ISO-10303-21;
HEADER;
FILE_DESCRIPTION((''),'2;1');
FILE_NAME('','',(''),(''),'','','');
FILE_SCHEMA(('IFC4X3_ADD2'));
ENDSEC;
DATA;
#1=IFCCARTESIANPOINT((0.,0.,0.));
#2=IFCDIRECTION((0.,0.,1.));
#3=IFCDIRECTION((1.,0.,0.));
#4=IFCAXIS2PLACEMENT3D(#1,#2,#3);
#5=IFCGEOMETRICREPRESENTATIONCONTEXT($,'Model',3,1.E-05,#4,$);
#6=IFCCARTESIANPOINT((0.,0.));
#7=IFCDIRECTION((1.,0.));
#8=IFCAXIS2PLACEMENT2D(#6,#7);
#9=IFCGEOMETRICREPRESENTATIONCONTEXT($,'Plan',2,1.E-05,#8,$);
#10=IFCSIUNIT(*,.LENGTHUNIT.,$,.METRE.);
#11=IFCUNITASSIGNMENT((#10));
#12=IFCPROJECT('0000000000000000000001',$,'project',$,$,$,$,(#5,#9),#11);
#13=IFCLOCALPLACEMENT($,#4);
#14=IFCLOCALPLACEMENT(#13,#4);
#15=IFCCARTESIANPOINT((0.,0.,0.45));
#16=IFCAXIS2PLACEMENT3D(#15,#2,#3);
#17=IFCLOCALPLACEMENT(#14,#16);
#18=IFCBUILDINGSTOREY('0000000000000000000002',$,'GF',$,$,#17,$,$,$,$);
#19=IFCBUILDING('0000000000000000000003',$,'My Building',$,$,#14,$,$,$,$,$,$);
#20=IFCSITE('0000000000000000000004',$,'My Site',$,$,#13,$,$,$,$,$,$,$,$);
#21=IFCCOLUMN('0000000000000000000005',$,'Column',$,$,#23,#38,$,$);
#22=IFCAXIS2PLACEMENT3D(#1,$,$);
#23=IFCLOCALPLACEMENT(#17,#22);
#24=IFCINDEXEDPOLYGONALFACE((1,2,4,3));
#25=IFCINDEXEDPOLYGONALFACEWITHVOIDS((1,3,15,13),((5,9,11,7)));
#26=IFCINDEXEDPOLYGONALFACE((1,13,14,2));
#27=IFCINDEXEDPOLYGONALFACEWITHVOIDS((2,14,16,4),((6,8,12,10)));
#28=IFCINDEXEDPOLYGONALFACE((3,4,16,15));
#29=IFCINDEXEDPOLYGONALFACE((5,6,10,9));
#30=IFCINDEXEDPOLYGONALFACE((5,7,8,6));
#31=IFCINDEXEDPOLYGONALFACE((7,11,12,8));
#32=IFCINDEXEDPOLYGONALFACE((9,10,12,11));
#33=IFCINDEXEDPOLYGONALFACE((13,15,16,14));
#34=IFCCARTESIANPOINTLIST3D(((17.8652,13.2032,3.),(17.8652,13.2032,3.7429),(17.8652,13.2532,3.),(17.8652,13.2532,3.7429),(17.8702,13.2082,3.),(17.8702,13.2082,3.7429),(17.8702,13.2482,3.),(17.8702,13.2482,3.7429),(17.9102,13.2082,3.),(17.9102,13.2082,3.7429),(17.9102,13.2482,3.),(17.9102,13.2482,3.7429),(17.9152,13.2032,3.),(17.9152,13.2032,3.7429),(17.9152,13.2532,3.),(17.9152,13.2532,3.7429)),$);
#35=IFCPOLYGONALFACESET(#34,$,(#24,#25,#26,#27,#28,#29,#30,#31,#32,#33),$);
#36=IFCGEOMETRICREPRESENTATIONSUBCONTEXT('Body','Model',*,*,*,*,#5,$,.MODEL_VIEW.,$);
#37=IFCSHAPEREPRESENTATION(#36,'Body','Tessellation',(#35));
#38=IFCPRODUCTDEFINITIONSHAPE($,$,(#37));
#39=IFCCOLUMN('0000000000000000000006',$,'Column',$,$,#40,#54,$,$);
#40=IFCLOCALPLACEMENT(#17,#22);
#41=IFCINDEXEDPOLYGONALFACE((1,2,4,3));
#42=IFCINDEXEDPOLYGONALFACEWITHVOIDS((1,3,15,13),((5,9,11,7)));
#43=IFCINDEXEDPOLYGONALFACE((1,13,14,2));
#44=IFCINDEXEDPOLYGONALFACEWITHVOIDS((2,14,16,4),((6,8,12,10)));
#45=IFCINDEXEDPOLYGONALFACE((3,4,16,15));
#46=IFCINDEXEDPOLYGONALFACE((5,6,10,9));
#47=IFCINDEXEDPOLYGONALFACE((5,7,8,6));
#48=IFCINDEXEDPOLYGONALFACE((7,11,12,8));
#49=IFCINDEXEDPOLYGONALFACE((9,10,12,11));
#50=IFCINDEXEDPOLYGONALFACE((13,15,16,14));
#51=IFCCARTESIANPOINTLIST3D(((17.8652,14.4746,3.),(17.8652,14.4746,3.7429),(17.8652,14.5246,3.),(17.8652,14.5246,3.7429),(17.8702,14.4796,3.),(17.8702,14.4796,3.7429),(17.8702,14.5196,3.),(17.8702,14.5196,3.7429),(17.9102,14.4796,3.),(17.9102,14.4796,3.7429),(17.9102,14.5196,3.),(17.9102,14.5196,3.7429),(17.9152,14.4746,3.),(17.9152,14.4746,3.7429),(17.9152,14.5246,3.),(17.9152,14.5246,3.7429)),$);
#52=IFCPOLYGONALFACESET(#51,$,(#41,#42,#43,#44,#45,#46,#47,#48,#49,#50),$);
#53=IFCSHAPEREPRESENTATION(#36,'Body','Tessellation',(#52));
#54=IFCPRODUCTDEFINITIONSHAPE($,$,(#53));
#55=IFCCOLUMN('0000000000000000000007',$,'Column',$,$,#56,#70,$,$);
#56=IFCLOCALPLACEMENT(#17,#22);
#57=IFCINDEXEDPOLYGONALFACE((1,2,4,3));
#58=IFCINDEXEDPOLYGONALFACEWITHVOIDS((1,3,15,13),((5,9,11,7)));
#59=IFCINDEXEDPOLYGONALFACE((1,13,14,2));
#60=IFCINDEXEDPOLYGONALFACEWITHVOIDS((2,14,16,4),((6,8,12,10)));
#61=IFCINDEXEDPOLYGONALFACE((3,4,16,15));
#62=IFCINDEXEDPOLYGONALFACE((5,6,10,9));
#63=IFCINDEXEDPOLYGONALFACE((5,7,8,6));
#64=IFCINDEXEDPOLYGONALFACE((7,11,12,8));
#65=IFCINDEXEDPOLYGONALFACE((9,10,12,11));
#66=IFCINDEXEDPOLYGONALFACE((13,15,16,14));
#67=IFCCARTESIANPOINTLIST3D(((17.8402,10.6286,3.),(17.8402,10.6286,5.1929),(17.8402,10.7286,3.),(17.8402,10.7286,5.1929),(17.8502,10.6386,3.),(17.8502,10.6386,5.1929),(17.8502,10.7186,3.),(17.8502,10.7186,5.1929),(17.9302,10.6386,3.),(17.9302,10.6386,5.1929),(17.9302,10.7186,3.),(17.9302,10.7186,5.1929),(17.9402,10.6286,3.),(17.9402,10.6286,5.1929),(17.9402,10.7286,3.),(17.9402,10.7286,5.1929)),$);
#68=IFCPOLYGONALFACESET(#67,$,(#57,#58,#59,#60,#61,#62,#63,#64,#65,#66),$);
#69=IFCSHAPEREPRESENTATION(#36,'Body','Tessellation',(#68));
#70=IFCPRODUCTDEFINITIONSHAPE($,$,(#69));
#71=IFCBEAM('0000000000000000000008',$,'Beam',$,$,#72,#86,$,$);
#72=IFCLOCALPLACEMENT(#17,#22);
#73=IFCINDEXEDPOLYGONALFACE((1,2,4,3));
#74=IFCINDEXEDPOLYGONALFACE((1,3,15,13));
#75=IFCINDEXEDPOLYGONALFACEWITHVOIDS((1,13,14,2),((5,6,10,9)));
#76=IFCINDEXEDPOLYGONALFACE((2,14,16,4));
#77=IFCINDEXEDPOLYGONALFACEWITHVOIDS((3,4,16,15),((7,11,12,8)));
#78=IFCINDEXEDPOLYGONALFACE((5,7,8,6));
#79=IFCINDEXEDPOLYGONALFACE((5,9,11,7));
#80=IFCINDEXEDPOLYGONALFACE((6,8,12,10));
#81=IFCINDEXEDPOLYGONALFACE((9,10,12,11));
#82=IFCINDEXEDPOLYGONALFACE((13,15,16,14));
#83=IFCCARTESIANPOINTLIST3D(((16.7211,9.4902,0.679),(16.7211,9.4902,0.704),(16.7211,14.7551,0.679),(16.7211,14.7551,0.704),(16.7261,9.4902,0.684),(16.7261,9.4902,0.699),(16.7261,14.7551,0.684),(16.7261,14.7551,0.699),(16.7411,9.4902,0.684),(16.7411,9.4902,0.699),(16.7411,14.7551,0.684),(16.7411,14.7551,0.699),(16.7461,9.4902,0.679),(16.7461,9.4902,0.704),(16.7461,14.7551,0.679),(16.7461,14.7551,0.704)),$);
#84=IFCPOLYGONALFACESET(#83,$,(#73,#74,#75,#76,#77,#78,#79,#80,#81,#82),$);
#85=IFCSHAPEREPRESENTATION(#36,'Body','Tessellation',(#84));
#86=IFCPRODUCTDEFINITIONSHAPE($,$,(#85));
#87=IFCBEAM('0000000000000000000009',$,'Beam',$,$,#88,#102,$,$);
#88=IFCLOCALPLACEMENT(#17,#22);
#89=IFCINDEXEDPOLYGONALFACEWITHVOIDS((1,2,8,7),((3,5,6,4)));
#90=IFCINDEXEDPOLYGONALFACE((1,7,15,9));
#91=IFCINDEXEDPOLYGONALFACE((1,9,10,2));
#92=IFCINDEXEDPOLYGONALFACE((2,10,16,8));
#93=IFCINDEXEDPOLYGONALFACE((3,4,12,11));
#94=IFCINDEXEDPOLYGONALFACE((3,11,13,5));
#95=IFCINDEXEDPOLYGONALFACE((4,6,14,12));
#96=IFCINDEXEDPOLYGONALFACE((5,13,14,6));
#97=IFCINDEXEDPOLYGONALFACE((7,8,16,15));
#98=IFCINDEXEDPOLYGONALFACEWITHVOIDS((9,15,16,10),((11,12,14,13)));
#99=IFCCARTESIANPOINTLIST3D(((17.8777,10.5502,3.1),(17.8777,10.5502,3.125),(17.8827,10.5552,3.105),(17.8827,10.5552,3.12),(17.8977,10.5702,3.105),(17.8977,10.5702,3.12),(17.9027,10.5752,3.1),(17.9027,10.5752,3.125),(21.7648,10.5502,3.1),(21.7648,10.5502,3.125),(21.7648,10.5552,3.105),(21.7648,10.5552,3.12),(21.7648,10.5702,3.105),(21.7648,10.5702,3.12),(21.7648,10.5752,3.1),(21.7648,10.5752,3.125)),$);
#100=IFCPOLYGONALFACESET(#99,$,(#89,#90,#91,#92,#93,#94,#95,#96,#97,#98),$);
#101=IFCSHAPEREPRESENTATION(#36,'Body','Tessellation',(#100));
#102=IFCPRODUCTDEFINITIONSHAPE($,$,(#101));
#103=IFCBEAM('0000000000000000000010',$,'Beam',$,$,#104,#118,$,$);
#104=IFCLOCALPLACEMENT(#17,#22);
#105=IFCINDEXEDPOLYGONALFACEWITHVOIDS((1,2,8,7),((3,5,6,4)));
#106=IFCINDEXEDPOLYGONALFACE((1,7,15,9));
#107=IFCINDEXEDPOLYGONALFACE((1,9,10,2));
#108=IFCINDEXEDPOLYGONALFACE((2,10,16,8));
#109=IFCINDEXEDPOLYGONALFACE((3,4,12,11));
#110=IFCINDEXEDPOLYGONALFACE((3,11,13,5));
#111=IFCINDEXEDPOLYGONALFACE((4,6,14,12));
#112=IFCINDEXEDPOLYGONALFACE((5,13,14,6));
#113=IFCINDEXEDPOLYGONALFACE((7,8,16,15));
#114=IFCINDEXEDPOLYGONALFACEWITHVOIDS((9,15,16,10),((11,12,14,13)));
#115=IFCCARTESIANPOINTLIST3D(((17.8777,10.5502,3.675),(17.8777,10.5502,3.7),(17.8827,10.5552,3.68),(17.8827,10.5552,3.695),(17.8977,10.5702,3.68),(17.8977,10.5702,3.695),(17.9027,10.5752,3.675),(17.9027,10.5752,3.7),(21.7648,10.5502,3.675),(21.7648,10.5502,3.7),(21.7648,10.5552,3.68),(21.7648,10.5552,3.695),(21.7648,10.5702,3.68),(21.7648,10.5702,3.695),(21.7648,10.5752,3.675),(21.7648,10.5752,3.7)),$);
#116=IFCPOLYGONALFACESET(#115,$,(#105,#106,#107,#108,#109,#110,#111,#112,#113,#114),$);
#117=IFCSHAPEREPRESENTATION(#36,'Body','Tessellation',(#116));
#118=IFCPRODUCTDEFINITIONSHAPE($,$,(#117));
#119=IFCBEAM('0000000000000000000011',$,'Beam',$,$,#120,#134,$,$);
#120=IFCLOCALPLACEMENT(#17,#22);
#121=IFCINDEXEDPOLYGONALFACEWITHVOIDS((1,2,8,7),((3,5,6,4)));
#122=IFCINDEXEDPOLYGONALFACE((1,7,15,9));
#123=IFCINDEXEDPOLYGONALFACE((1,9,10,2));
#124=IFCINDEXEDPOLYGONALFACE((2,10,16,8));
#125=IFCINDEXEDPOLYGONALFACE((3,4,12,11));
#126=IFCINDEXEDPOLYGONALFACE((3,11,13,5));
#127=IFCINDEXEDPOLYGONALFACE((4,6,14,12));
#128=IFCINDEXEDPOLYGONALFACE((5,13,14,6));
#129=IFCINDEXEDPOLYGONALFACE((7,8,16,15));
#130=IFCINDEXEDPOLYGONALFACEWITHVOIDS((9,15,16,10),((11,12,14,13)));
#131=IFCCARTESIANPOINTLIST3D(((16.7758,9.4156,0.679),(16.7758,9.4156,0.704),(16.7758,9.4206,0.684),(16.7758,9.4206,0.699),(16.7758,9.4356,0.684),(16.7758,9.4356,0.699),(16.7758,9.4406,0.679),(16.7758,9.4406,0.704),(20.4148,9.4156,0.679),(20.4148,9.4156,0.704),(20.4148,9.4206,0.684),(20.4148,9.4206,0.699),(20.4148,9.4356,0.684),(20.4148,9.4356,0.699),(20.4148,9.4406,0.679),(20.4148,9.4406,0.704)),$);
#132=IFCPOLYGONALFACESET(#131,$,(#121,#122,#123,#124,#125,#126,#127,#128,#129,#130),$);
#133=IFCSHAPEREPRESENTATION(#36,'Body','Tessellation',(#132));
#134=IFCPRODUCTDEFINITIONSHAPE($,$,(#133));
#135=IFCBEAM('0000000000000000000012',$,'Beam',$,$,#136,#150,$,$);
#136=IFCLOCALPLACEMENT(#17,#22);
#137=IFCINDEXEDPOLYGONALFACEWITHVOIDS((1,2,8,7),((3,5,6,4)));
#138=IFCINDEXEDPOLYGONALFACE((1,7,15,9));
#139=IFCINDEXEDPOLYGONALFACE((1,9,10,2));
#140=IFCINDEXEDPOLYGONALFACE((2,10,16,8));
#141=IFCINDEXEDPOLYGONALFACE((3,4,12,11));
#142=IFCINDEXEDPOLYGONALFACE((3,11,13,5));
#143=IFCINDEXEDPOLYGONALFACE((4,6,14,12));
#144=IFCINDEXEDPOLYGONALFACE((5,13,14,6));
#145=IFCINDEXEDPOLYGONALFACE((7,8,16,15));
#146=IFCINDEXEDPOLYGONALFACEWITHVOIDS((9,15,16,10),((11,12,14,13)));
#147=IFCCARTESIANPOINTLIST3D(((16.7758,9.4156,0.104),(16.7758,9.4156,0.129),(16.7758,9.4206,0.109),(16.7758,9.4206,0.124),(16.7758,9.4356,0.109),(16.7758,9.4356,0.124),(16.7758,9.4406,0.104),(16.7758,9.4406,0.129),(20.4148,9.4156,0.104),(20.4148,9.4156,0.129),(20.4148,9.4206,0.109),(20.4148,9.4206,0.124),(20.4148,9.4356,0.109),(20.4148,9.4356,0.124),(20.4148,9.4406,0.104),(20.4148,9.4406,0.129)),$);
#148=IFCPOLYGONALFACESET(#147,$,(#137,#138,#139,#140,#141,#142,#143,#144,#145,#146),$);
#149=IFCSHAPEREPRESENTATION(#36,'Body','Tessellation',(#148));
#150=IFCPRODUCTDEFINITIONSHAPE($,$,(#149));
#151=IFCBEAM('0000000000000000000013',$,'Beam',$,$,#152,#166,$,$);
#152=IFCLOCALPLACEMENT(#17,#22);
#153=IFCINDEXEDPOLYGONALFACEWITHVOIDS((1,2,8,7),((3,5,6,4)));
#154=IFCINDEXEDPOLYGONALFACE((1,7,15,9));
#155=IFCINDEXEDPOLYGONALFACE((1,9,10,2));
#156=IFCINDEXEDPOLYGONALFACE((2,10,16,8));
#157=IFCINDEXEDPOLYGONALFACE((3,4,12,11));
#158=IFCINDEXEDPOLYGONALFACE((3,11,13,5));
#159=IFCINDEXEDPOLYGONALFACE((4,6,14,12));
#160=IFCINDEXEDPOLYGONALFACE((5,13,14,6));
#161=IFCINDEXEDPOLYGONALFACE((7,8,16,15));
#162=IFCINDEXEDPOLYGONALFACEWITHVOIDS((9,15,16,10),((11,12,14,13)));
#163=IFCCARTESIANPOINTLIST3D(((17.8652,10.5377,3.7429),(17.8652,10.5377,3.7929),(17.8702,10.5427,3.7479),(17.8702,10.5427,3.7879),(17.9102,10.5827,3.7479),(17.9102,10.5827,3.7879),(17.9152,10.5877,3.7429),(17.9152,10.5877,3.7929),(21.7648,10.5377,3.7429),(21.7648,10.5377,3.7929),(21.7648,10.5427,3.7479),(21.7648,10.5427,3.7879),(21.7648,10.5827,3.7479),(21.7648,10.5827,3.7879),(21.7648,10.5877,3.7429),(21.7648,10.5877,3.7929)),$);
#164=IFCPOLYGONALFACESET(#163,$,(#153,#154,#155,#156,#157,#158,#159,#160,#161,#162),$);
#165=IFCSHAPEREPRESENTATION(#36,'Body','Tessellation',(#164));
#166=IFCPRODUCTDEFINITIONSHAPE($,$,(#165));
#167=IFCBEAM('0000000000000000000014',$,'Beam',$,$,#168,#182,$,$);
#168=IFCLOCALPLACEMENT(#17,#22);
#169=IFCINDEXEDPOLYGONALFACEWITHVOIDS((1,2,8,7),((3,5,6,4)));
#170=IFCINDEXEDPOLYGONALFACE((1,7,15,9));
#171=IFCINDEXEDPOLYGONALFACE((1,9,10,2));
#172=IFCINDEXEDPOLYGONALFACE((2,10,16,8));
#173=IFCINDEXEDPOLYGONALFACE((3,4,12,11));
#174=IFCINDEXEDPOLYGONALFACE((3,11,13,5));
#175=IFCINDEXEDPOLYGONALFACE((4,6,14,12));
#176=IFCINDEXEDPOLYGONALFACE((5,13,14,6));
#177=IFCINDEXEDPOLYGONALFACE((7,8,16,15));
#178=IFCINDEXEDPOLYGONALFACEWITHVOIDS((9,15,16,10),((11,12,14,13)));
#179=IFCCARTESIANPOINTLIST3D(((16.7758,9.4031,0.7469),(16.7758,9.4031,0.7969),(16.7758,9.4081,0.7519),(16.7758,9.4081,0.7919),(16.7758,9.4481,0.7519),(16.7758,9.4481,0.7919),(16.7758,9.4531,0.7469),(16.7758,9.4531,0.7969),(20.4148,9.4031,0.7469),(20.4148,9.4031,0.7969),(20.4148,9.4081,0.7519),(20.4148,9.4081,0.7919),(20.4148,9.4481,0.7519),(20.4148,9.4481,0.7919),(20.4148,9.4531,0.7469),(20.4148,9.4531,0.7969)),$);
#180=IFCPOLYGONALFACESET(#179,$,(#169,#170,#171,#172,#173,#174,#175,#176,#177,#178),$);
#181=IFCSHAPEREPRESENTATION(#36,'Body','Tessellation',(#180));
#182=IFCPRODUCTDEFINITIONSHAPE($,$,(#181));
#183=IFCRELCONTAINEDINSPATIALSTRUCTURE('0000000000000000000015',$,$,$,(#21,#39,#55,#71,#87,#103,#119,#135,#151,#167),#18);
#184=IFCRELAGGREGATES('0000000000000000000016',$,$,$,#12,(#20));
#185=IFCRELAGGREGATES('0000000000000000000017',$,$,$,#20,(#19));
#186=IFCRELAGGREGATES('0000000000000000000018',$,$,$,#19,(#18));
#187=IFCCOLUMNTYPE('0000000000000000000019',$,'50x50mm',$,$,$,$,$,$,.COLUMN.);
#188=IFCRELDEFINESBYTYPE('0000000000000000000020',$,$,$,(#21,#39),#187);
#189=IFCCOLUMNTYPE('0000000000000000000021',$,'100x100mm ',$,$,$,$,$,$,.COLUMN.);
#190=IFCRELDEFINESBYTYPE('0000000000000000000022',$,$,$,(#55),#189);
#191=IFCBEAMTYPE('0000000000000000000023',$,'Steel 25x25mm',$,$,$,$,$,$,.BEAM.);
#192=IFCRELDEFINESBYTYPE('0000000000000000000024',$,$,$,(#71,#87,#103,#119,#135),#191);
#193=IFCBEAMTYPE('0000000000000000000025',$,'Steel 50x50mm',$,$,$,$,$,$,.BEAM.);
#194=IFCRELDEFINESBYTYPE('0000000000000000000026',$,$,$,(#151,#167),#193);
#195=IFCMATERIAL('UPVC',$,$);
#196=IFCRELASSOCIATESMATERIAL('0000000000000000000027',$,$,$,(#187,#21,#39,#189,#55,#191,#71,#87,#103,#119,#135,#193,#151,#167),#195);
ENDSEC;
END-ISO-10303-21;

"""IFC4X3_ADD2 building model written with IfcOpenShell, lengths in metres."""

from ifc_helpers import new_model, entity, si_unit, frame, origin_with_axes, origin_2d_with_axis, place, context, subcontext, project, spatial, hollow_rectangle, extrude, clip, halfspace, shape, material, material_profile, profile_set, profile_usage, type_object, element, save


model = new_model("IFC4X3_ADD2")

# Units and contexts
model_context = context("Model", 3, precision=1e-05, world=origin_with_axes())
plan_context = context("Plan", 2, precision=1e-05, world=origin_2d_with_axis())
body_context_1 = subcontext(model_context, "Body", "Model", "MODEL_VIEW")
body_context_2 = subcontext(plan_context, "Body", "Plan", "PLAN_VIEW")
ifc_project = project(units=[si_unit("LENGTHUNIT", "METRE")], contexts=[model_context, plan_context])

# Site, building, storey
site_placement = place(None, origin_with_axes())
site = spatial("IfcSite", under=ifc_project, at=site_placement, Name="My Site")
building_placement = place(site_placement, origin_with_axes())
building = spatial("IfcBuilding", under=site, at=building_placement, Name="My Building")
storey_placement = place(building_placement, frame((0.0, 0.0, 0.45), z_axis=(0.0, 0.0, 1.0), x_axis=(1.0, 0.0, 0.0)))
storey = spatial("IfcBuildingStorey", under=building, at=storey_placement, Name="GF")

# Columns
ifc_material_1 = material(Name="UPVC")
ifc_material_profile_1 = material_profile(ifc_material_1, hollow_rectangle(XDim=0.05, YDim=0.05, WallThickness=0.005))
ifc_profile_set_1 = profile_set([ifc_material_profile_1])
column_type_1 = type_object("IfcColumnType", Name="50x50mm", PredefinedType="COLUMN", material=ifc_profile_set_1)
ifc_profile_usage_1 = profile_usage(ifc_profile_set_1)
column_1_placement = place(storey_placement, frame((17.8902, 13.2282, 3.0), z_axis=(0.0, 0.0, 1.0), x_axis=(0.0, -1.0, 0.0)))
element("IfcColumn", 1, at=column_1_placement, inside=storey, type_object=column_type_1, material=ifc_profile_usage_1, Name="Column", context=body_context_1, shape_type="SweptSolid", body=[
    extrude(hollow_rectangle(XDim=0.05, YDim=0.05, WallThickness=0.005), origin_with_axes(), (0.0, 0.0, 1.0), 0.7429),
])
ifc_profile_usage_2 = profile_usage(ifc_profile_set_1)
column_2_placement = place(storey_placement, frame((17.8902, 14.4996, 3.0), z_axis=(0.0, 0.0, 1.0), x_axis=(0.0, -1.0, 0.0)))
element("IfcColumn", 2, at=column_2_placement, inside=storey, type_object=column_type_1, material=ifc_profile_usage_2, Name="Column", context=body_context_1, shape_type="SweptSolid", body=[
    extrude(hollow_rectangle(XDim=0.05, YDim=0.05, WallThickness=0.005), origin_with_axes(), (0.0, 0.0, 1.0), 0.7429),
])
ifc_material_profile_2 = material_profile(ifc_material_1, hollow_rectangle(XDim=0.1, YDim=0.1, WallThickness=0.01))
ifc_profile_set_2 = profile_set([ifc_material_profile_2])
ifc_profile_usage_3 = profile_usage(ifc_profile_set_2)
column_type_2 = type_object("IfcColumnType", Name="100x100mm ", PredefinedType="COLUMN", material=ifc_profile_set_2)
column_3_placement = place(storey_placement, frame((17.8902, 10.6786, 3.0), z_axis=(0.0, 0.0, 1.0), x_axis=(0.0, -1.0, 0.0)))
element("IfcColumn", 3, at=column_3_placement, inside=storey, type_object=column_type_2, material=ifc_profile_usage_3, Name="Column", shapes=[
    shape(body_context_1, "Body", "SweptSolid", [extrude(hollow_rectangle(XDim=0.1, YDim=0.1, WallThickness=0.01), origin_with_axes(), (0.0, 0.0, 1.0), 2.1929)]),
    shape(body_context_2, "Body", "Annotation2D", [entity("IfcGeometricCurveSet", [entity("IfcIndexedPolyCurve", entity("IfcCartesianPointList2D", [[0.04, -0.04], [0.04, 0.04], [-0.04, 0.04], [-0.04, -0.04]]), [entity("IfcLineIndex", [1, 2, 3, 4, 1])]), entity("IfcIndexedPolyCurve", entity("IfcCartesianPointList2D", [[-0.05, -0.05], [0.05, -0.05], [0.05, 0.05], [-0.05, 0.05]]), [entity("IfcLineIndex", [1, 2, 3, 4, 1])])])]),
])

# Beams
ifc_material_profile_3 = material_profile(ifc_material_1, hollow_rectangle(XDim=0.025, YDim=0.025, WallThickness=0.005))
ifc_profile_set_3 = profile_set([ifc_material_profile_3])
ifc_profile_usage_4 = profile_usage(ifc_profile_set_3)
beam_type_1 = type_object("IfcBeamType", Name="Steel 25x25mm", PredefinedType="BEAM", material=ifc_profile_set_3)
beam_1_placement = place(storey_placement, frame((16.7336, 14.7551, 0.6915), z_axis=(0.0, -1.0, 0.0), x_axis=(1.0, 0.0, 0.0)))
element("IfcBeam", 4, at=beam_1_placement, inside=storey, type_object=beam_type_1, material=ifc_profile_usage_4, Name="Beam", context=body_context_1, shape_type="SweptSolid", body=[
    extrude(hollow_rectangle(XDim=0.025, YDim=0.025, WallThickness=0.005), origin_with_axes(), (0.0, 0.0, 1.0), 5.2649),
])
ifc_profile_usage_5 = profile_usage(ifc_profile_set_3)
beam_2_placement = place(storey_placement, frame((17.8777, 10.5627, 3.1125), z_axis=(1.0, 0.0, 0.0), x_axis=(0.0, 1.0, 0.0)))
element("IfcBeam", 5, at=beam_2_placement, inside=storey, type_object=beam_type_1, material=ifc_profile_usage_5, Name="Beam", context=body_context_1, shape_type="Clipping", body=[
    clip(extrude(hollow_rectangle(XDim=0.025, YDim=0.025, WallThickness=0.005), origin_with_axes(), (0.0, 0.0, 1.0), 3.8871), halfspace(frame((-0.0125, -3.5625, 0.0), z_axis=(0.707134, 0.0, -0.70708), x_axis=(0.0, -1.0, 0.0)), False)),
])
ifc_profile_usage_6 = profile_usage(ifc_profile_set_3)
beam_3_placement = place(storey_placement, frame((17.8777, 10.5627, 3.6875), z_axis=(1.0, 0.0, 0.0), x_axis=(0.0, 1.0, 0.0)))
element("IfcBeam", 6, at=beam_3_placement, inside=storey, type_object=beam_type_1, material=ifc_profile_usage_6, Name="Beam", context=body_context_1, shape_type="Clipping", body=[
    clip(extrude(hollow_rectangle(XDim=0.025, YDim=0.025, WallThickness=0.005), origin_with_axes(), (0.0, 0.0, 1.0), 3.8871), halfspace(frame((-0.0125, -4.1375, 0.0), z_axis=(0.707134, 0.0, -0.70708), x_axis=(0.0, -1.0, 0.0)), False)),
])
ifc_profile_usage_7 = profile_usage(ifc_profile_set_3)
beam_4_placement = place(storey_placement, frame((16.7758, 9.4281, 0.6915), z_axis=(1.0, 0.0, 0.0), x_axis=(0.0, 1.0, 0.0)))
element("IfcBeam", 7, at=beam_4_placement, inside=storey, type_object=beam_type_1, material=ifc_profile_usage_7, Name="Beam", context=body_context_1, shape_type="SweptSolid", body=[
    extrude(hollow_rectangle(XDim=0.025, YDim=0.025, WallThickness=0.005), origin_with_axes(), (0.0, 0.0, 1.0), 3.6389),
])
ifc_profile_usage_8 = profile_usage(ifc_profile_set_3)
beam_5_placement = place(storey_placement, frame((16.7758, 9.4281, 0.1165), z_axis=(1.0, 0.0, 0.0), x_axis=(0.0, 1.0, 0.0)))
element("IfcBeam", 8, at=beam_5_placement, inside=storey, type_object=beam_type_1, material=ifc_profile_usage_8, Name="Beam", context=body_context_1, shape_type="SweptSolid", body=[
    extrude(hollow_rectangle(XDim=0.025, YDim=0.025, WallThickness=0.005), origin_with_axes(), (0.0, 0.0, 1.0), 3.6389),
])
ifc_material_profile_4 = material_profile(ifc_material_1, hollow_rectangle(XDim=0.05, YDim=0.05, WallThickness=0.005))
ifc_profile_set_4 = profile_set([ifc_material_profile_4])
ifc_profile_usage_9 = profile_usage(ifc_profile_set_4)
beam_type_2 = type_object("IfcBeamType", Name="Steel 50x50mm", PredefinedType="BEAM", material=ifc_profile_set_4)
beam_6_placement = place(storey_placement, frame((17.8652, 10.5627, 3.7679), z_axis=(1.0, 0.0, 0.0), x_axis=(0.0, 1.0, 0.0)))
element("IfcBeam", 9, at=beam_6_placement, inside=storey, type_object=beam_type_2, material=ifc_profile_usage_9, Name="Beam", context=body_context_1, shape_type="Clipping", body=[
    clip(extrude(hollow_rectangle(XDim=0.05, YDim=0.05, WallThickness=0.005), origin_with_axes(), (0.0, 0.0, 1.0), 3.8996), halfspace(frame((-0.025, -4.2179, 0.0), z_axis=(0.707107, 0.0, -0.707107), x_axis=(0.0, -1.0, 0.0)), False)),
])
ifc_profile_usage_10 = profile_usage(ifc_profile_set_4)
beam_7_placement = place(storey_placement, frame((16.7758, 9.4281, 0.7719), z_axis=(1.0, 0.0, 0.0), x_axis=(0.0, 1.0, 0.0)))
element("IfcBeam", 10, at=beam_7_placement, inside=storey, type_object=beam_type_2, material=ifc_profile_usage_10, Name="Beam", context=body_context_1, shape_type="SweptSolid", body=[
    extrude(hollow_rectangle(XDim=0.05, YDim=0.05, WallThickness=0.005), origin_with_axes(), (0.0, 0.0, 1.0), 3.6389),
])

save(model, "model.ifc")
